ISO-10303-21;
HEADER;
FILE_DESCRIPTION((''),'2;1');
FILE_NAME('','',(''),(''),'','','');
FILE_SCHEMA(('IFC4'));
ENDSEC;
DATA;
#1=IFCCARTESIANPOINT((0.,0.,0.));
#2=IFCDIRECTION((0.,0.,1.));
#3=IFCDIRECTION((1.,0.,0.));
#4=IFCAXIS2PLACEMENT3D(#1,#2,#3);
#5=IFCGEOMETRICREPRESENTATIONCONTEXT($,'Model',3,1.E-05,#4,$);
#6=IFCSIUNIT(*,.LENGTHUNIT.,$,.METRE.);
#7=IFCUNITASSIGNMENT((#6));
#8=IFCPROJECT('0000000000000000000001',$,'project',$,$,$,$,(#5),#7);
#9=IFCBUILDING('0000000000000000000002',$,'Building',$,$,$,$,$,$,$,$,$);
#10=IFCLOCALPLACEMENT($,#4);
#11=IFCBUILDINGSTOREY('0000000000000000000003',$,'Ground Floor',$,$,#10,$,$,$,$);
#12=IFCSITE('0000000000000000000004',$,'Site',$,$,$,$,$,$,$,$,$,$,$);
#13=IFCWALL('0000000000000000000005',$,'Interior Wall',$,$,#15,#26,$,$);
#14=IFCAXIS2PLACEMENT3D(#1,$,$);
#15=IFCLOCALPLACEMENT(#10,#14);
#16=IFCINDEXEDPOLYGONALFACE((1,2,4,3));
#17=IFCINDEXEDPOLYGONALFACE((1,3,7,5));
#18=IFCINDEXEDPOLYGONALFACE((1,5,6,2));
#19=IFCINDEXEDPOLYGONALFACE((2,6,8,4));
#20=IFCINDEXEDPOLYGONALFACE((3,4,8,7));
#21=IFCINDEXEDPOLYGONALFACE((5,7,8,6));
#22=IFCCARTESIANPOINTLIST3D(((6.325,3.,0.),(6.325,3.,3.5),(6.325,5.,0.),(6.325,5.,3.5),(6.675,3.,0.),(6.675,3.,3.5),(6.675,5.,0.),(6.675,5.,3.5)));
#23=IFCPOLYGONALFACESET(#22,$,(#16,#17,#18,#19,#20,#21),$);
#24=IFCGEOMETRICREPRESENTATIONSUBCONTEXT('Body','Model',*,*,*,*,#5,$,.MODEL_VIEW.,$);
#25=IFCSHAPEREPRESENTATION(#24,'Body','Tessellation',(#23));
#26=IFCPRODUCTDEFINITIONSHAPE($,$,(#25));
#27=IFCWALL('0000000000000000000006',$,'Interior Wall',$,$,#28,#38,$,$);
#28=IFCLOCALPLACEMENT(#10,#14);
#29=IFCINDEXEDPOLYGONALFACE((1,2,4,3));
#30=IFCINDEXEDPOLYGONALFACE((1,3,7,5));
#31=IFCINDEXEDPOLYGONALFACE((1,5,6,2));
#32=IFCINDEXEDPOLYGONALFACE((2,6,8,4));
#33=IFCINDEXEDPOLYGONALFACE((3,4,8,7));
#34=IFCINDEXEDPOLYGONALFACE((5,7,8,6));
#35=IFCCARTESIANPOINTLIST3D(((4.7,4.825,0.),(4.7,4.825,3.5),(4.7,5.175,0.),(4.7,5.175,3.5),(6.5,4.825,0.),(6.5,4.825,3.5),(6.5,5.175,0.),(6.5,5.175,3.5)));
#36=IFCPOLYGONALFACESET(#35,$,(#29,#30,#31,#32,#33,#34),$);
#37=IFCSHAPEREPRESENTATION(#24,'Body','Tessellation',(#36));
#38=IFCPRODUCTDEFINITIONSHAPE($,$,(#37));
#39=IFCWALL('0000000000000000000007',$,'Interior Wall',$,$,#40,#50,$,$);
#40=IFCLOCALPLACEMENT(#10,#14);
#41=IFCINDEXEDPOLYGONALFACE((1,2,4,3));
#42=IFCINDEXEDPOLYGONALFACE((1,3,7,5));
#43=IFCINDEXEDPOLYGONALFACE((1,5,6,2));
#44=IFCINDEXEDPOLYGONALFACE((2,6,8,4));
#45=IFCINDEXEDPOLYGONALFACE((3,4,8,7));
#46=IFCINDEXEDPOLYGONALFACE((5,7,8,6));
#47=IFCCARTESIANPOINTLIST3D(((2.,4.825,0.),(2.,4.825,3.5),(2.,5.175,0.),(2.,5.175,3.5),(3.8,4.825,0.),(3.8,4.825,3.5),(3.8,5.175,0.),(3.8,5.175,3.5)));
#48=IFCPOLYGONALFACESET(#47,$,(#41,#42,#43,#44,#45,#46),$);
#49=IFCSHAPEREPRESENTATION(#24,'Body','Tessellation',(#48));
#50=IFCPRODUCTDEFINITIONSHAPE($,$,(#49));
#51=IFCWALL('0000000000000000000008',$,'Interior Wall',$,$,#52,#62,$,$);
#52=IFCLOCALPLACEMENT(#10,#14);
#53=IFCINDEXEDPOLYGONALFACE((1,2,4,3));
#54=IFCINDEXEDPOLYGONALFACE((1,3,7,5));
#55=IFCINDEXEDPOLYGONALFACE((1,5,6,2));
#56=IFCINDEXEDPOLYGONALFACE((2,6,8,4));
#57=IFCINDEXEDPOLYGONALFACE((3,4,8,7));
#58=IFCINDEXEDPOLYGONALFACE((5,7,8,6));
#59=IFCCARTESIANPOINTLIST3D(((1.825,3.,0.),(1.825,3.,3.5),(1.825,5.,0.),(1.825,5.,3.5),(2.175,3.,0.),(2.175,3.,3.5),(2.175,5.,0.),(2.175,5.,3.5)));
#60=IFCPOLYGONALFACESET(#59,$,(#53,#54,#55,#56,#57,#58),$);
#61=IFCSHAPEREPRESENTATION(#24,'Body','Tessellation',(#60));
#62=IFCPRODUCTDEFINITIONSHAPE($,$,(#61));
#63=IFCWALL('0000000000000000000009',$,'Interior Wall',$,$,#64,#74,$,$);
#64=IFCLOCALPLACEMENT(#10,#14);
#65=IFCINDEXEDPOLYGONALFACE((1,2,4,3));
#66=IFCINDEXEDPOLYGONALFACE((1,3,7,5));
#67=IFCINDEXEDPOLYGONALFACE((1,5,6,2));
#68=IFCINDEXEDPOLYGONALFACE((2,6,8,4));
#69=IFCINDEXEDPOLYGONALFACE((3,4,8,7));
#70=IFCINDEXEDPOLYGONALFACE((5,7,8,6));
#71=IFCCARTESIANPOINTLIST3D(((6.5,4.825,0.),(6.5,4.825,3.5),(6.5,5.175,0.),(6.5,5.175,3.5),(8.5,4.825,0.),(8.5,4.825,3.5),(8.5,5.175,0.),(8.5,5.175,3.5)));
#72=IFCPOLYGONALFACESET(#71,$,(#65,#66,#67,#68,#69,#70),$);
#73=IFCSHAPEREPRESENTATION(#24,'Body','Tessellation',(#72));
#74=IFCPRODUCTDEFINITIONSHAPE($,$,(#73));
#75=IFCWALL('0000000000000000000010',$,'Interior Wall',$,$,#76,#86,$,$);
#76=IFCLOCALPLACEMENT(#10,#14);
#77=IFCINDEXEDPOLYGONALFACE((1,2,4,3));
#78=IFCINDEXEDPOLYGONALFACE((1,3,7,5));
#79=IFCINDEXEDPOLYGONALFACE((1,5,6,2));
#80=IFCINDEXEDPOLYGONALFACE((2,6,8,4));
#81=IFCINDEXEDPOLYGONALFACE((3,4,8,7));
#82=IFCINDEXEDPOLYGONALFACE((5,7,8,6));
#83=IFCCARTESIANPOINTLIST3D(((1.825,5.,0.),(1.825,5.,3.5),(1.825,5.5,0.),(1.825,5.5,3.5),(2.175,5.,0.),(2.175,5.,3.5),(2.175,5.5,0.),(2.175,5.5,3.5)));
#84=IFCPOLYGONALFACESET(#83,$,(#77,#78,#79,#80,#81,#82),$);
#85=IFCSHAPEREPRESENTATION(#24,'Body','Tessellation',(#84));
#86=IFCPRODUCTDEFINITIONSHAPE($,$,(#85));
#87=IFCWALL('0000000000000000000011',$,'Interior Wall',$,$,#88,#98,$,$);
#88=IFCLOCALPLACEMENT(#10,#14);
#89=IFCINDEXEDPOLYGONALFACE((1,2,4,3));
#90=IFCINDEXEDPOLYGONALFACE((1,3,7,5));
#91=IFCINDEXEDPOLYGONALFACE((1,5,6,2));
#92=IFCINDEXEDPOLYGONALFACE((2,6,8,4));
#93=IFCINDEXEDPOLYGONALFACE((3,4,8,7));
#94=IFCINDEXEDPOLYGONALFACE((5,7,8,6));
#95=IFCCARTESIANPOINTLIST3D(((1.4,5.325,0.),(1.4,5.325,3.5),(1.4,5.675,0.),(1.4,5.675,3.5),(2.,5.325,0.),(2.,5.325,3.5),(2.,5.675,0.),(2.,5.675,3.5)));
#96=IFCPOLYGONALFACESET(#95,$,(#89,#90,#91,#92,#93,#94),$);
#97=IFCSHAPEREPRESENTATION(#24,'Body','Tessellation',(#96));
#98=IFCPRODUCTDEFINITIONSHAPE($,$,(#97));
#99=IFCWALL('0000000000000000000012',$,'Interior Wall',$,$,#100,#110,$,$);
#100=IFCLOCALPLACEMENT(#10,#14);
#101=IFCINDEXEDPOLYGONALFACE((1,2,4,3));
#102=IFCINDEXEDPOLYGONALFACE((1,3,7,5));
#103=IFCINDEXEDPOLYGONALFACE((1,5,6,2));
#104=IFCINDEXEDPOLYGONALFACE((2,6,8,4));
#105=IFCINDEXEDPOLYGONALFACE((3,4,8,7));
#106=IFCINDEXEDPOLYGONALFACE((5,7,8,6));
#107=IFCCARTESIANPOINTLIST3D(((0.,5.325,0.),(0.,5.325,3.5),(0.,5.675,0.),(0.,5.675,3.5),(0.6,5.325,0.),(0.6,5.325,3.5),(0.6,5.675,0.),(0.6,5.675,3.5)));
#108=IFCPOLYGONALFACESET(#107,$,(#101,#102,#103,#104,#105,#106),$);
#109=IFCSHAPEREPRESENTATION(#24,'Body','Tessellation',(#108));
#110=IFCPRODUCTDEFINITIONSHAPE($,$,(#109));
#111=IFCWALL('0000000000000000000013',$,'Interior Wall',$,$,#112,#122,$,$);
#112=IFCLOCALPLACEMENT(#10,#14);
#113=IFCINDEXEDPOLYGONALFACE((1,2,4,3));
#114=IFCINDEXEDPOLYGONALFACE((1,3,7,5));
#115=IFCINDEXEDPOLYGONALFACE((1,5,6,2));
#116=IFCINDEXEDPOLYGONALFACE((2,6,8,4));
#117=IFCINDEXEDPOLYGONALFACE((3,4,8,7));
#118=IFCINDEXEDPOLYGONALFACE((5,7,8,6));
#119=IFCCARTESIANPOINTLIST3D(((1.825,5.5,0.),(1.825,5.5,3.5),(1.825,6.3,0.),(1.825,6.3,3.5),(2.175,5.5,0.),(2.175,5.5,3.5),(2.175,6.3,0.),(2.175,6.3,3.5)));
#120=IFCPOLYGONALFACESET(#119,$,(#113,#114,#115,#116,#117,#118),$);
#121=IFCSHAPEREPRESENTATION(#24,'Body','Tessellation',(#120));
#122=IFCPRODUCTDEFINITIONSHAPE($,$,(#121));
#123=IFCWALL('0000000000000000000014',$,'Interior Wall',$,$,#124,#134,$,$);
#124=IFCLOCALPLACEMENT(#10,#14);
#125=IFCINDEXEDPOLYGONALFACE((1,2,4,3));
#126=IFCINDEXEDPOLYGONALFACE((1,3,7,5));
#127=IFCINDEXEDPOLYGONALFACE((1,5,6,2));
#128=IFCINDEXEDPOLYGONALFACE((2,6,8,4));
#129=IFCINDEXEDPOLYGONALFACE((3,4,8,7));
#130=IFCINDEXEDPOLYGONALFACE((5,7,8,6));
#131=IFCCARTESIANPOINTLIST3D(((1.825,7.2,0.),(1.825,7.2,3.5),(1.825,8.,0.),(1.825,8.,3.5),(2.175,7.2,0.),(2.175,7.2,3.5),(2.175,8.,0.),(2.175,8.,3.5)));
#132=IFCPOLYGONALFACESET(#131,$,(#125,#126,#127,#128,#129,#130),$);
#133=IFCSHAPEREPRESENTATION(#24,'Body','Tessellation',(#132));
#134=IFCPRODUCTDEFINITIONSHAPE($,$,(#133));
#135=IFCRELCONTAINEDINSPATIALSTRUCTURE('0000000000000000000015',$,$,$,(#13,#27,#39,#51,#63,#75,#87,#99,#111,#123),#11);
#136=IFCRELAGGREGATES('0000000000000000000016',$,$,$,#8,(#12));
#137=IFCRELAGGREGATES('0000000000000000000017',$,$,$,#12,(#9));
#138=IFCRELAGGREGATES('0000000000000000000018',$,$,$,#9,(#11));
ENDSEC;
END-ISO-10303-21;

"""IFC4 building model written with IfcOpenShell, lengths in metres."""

from ifc_helpers import new_model, si_unit, frame, origin_with_axes, place, context, subcontext, project, spatial, indexed_curve, outline, extrude, element, save


model = new_model("IFC4")

# Units and contexts
model_context = context("Model", 3, precision=1e-05, world=origin_with_axes())
body_context = subcontext(model_context, "Body", "Model", "MODEL_VIEW")
ifc_project = project(units=[si_unit("LENGTHUNIT", "METRE")], contexts=[model_context])

# Site, building, storey
site = spatial("IfcSite", under=ifc_project, Name="Site")
building = spatial("IfcBuilding", under=site, Name="Building")
storey_placement = place(None, origin_with_axes())
storey = spatial("IfcBuildingStorey", under=building, at=storey_placement, Name="Ground Floor")

# Walls
for number, where, z_axis, x_axis, name in (
    (1, (6.5, 3.0, 0.0), (0.0, 0.0, 1.0), (0.0, 1.0, 0.0), "Interior Wall"),
):
    element("IfcWall", number, at=place(storey_placement, frame(where, z_axis=z_axis, x_axis=x_axis)), inside=storey, Name=name, context=body_context, shape_type="SweptSolid", body=[
        extrude(outline(indexed_curve([(0.0, 0.0), (0.0, 0.35), (2.0, 0.35), (2.0, 0.0), (0.0, 0.0)], self_intersect=False)), frame((0.0, -0.175, 0.0), z_axis=(0.0, 0.0, 1.0), x_axis=(1.0, 0.0, 0.0)), (0.0, 0.0, 1.0), 3.5),
    ])
for number, where, z_axis, x_axis, name in (
    (2, (6.5, 5.0, 0.0), (0.0, 0.0, 1.0), (-1.0, 0.0, 0.0), "Interior Wall"),
    (3, (3.8, 5.0, 0.0), (0.0, 0.0, 1.0), (-1.0, 0.0, 0.0), "Interior Wall"),
):
    element("IfcWall", number, at=place(storey_placement, frame(where, z_axis=z_axis, x_axis=x_axis)), inside=storey, Name=name, context=body_context, shape_type="SweptSolid", body=[
        extrude(outline(indexed_curve([(0.0, 0.0), (0.0, 0.35), (1.8, 0.35), (1.8, 0.0), (0.0, 0.0)], self_intersect=False)), frame((0.0, -0.175, 0.0), z_axis=(0.0, 0.0, 1.0), x_axis=(1.0, 0.0, 0.0)), (0.0, 0.0, 1.0), 3.5),
    ])
for number, where, z_axis, x_axis, name in (
    (4, (2.0, 5.0, 0.0), (0.0, 0.0, 1.0), (0.0, -1.0, 0.0), "Interior Wall"),
    (5, (8.5, 5.0, 0.0), (0.0, 0.0, 1.0), (-1.0, 0.0, 0.0), "Interior Wall"),
):
    element("IfcWall", number, at=place(storey_placement, frame(where, z_axis=z_axis, x_axis=x_axis)), inside=storey, Name=name, context=body_context, shape_type="SweptSolid", body=[
        extrude(outline(indexed_curve([(0.0, 0.0), (0.0, 0.35), (2.0, 0.35), (2.0, 0.0), (0.0, 0.0)], self_intersect=False)), frame((0.0, -0.175, 0.0), z_axis=(0.0, 0.0, 1.0), x_axis=(1.0, 0.0, 0.0)), (0.0, 0.0, 1.0), 3.5),
    ])
wall_1_placement = place(storey_placement, frame((2.0, 5.0, 0.0), z_axis=(0.0, 0.0, 1.0), x_axis=(0.0, 1.0, 0.0)))
element("IfcWall", 6, at=wall_1_placement, inside=storey, Name="Interior Wall", context=body_context, shape_type="SweptSolid", body=[
    extrude(outline(indexed_curve([(0.0, 0.0), (0.0, 0.35), (0.5, 0.35), (0.5, 0.0), (0.0, 0.0)], self_intersect=False)), frame((0.0, -0.175, 0.0), z_axis=(0.0, 0.0, 1.0), x_axis=(1.0, 0.0, 0.0)), (0.0, 0.0, 1.0), 3.5),
])
for number, where, z_axis, x_axis, name in (
    (7, (2.0, 5.5, 0.0), (0.0, 0.0, 1.0), (-1.0, 0.0, 0.0), "Interior Wall"),
    (8, (0.6, 5.5, 0.0), (0.0, 0.0, 1.0), (-1.0, 0.0, 0.0), "Interior Wall"),
):
    element("IfcWall", number, at=place(storey_placement, frame(where, z_axis=z_axis, x_axis=x_axis)), inside=storey, Name=name, context=body_context, shape_type="SweptSolid", body=[
        extrude(outline(indexed_curve([(0.0, 0.0), (0.0, 0.35), (0.6, 0.35), (0.6, 0.0), (0.0, 0.0)], self_intersect=False)), frame((0.0, -0.175, 0.0), z_axis=(0.0, 0.0, 1.0), x_axis=(1.0, 0.0, 0.0)), (0.0, 0.0, 1.0), 3.5),
    ])
for number, where, z_axis, x_axis, name in (
    (9, (2.0, 5.5, 0.0), (0.0, 0.0, 1.0), (0.0, 1.0, 0.0), "Interior Wall"),
    (10, (2.0, 7.2, 0.0), (0.0, 0.0, 1.0), (0.0, 1.0, 0.0), "Interior Wall"),
):
    element("IfcWall", number, at=place(storey_placement, frame(where, z_axis=z_axis, x_axis=x_axis)), inside=storey, Name=name, context=body_context, shape_type="SweptSolid", body=[
        extrude(outline(indexed_curve([(0.0, 0.0), (0.0, 0.35), (0.8, 0.35), (0.8, 0.0), (0.0, 0.0)], self_intersect=False)), frame((0.0, -0.175, 0.0), z_axis=(0.0, 0.0, 1.0), x_axis=(1.0, 0.0, 0.0)), (0.0, 0.0, 1.0), 3.5),
    ])

save(model, "model.ifc")
